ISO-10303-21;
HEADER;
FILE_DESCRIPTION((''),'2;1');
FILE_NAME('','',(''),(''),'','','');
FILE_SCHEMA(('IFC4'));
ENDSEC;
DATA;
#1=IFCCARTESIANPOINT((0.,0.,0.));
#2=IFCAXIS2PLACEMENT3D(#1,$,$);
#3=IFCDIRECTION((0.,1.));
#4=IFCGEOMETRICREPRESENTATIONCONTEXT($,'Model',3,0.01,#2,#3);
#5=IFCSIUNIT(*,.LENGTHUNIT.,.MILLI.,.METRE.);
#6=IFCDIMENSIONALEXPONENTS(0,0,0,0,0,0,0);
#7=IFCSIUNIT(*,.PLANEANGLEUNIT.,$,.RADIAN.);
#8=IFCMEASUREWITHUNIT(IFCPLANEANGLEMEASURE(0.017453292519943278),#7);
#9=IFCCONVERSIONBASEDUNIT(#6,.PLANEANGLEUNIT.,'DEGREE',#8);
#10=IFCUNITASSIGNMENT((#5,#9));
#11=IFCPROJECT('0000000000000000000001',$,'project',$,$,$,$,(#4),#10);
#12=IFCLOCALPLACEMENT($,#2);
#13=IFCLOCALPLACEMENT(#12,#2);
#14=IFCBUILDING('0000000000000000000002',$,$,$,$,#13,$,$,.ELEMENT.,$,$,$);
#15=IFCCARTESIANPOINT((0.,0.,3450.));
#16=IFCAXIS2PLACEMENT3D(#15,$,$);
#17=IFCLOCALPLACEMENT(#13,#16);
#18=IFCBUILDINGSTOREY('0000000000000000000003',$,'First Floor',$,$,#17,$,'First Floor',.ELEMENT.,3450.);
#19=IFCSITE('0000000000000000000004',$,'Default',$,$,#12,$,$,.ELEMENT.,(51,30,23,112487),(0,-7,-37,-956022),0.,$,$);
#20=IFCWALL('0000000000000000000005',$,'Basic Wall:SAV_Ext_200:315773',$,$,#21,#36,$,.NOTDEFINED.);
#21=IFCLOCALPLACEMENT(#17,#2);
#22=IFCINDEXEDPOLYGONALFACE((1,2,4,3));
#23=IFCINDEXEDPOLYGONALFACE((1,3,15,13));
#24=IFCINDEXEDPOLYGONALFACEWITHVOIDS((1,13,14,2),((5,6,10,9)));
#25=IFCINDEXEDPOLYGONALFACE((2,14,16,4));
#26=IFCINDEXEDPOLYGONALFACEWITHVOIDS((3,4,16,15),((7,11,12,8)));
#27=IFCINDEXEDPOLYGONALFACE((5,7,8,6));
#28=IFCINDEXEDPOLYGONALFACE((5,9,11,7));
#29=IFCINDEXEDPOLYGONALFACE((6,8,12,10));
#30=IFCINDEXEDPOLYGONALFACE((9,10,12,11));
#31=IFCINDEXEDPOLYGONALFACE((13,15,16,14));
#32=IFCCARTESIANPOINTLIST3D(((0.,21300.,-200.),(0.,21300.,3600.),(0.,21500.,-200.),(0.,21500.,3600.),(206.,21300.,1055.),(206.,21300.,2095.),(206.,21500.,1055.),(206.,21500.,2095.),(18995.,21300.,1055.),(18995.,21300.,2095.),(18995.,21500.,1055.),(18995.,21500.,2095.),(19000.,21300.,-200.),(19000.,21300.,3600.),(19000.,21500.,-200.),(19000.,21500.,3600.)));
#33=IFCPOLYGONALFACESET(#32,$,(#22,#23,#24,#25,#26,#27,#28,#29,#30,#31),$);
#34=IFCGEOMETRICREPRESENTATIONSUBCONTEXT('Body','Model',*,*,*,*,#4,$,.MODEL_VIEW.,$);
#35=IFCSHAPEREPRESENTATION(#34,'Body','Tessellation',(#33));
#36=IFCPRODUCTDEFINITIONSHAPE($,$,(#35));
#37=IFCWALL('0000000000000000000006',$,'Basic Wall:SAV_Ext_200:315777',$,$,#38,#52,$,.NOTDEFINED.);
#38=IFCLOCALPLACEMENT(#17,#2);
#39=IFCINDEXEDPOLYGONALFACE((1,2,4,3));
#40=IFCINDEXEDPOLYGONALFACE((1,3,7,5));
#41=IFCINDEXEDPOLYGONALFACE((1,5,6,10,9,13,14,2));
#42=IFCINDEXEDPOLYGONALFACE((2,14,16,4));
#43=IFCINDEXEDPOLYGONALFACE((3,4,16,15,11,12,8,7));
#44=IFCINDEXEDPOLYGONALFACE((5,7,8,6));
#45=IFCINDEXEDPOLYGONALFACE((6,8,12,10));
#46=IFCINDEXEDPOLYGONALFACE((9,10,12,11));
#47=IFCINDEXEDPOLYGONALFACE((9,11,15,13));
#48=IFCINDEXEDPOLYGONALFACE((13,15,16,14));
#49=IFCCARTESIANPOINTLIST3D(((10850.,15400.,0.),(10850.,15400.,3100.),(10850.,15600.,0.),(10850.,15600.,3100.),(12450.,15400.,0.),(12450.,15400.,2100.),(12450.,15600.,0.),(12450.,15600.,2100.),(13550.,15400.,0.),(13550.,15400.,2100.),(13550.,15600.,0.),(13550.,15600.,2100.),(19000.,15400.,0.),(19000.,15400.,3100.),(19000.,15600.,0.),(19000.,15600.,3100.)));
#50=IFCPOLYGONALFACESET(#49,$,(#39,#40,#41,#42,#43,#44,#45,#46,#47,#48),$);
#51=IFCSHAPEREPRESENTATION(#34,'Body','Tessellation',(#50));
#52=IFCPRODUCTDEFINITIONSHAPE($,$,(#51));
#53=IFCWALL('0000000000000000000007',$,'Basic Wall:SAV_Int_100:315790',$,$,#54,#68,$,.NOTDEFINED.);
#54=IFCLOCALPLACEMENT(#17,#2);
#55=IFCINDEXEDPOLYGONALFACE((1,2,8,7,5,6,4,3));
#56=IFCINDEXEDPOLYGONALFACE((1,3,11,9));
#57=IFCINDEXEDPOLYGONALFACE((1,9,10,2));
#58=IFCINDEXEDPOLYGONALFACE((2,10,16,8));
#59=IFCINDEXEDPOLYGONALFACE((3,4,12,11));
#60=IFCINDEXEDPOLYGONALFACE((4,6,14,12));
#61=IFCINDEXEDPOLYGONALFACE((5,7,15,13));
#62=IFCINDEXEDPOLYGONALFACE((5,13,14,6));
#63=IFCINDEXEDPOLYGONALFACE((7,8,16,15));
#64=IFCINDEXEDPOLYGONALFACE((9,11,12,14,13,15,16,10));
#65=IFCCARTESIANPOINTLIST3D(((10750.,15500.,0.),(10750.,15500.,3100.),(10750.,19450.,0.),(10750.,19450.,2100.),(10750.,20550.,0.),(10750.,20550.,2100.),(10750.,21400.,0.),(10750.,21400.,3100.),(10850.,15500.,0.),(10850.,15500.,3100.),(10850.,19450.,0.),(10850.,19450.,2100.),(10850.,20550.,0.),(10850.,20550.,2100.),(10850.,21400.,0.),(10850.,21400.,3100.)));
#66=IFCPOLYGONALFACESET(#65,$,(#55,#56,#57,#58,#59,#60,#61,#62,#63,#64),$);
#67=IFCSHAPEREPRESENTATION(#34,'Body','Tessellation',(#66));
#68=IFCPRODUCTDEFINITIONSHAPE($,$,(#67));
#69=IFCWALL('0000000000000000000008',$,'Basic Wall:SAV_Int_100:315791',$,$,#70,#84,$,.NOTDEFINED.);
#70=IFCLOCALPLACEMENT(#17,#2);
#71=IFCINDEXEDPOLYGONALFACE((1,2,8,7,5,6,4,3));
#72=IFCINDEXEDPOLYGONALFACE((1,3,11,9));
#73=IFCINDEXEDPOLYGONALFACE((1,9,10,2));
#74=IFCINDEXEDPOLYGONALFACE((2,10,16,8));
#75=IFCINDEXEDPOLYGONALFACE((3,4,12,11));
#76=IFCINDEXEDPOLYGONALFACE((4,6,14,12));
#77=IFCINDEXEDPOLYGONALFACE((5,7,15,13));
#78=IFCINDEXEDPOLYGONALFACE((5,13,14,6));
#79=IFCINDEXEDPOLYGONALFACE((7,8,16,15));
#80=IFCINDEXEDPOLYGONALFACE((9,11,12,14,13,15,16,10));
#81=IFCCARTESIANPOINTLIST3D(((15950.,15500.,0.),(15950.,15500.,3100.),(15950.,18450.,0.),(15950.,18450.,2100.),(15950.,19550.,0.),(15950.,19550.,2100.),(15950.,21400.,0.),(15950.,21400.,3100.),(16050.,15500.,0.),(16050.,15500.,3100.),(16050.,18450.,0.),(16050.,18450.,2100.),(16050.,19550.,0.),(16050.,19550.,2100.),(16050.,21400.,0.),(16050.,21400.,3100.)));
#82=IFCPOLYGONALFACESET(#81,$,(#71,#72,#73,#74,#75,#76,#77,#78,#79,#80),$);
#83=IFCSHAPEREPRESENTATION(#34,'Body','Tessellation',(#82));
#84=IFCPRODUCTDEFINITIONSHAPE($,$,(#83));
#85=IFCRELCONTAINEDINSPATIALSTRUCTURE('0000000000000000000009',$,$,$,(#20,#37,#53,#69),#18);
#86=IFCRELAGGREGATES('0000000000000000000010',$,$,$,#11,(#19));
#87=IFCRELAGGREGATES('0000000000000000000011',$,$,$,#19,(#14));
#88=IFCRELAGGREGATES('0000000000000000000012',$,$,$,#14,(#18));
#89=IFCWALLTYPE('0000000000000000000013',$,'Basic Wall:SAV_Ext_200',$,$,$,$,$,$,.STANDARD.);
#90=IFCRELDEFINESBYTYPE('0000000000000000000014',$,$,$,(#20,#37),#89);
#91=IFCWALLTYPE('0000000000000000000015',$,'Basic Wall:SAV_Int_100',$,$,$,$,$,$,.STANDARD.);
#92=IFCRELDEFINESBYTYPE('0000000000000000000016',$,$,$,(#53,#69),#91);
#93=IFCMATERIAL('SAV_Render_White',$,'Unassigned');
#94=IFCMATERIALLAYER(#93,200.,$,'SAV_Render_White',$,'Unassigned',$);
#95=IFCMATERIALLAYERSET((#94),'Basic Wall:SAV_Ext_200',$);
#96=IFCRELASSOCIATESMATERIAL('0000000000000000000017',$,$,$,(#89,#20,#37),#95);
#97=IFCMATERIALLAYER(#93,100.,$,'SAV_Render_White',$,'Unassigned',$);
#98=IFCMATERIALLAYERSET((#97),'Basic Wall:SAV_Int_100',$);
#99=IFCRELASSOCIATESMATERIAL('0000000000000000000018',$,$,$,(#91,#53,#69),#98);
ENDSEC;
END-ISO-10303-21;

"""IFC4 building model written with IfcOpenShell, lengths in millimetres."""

from ifc_helpers import new_model, entity, si_unit, converted_unit, direction, frame, frame_2d, origin, place, context, subcontext, project, spatial, rectangle, extrude, material, layer, layer_set, layer_usage, type_object, element, save


model = new_model("IFC4")

# Units and contexts
model_context = context("Model", 3, precision=0.01, world=origin(), true_north=direction((0.0, 1.0)))
body_context = subcontext(model_context, "Body", "Model", "MODEL_VIEW")
ifc_project = project(units=[si_unit("LENGTHUNIT", "METRE", prefix="MILLI"), converted_unit("PLANEANGLEUNIT", "DEGREE", entity("IfcPlaneAngleMeasure", 0.017453292519943278), si_unit("PLANEANGLEUNIT", "RADIAN"), dimensions=[0, 0, 0, 0, 0, 0, 0])], contexts=[model_context])

# Site, building, storey
site_placement = place(None, origin())
site = spatial("IfcSite", under=ifc_project, at=site_placement, Name="Default", CompositionType="ELEMENT", RefLatitude=(51, 30, 23, 112487), RefLongitude=(0, -7, -37, -956022), RefElevation=0.0)
building_placement = place(site_placement, origin())
building = spatial("IfcBuilding", under=site, at=building_placement, CompositionType="ELEMENT")
storey_placement = place(building_placement, frame((0.0, 0.0, 3450.0)))
storey = spatial("IfcBuildingStorey", under=building, at=storey_placement, Name="First Floor", LongName="First Floor", CompositionType="ELEMENT", Elevation=3450.0)

# Walls, openings
ifc_material_1 = material(Name="SAV_Render_White", Category="Unassigned")
ifc_layer_1 = layer(ifc_material_1, 200.0, Name="SAV_Render_White", Category="Unassigned")
ifc_layer_set_1 = layer_set([ifc_layer_1], Name="Basic Wall:SAV_Ext_200")
ifc_layer_usage_1 = layer_usage(ifc_layer_set_1, "AXIS2", "NEGATIVE", 100.0)
wall_type_1 = type_object("IfcWallType", Name="Basic Wall:SAV_Ext_200", PredefinedType="STANDARD", material=ifc_layer_set_1)
wall_1_placement = place(storey_placement, frame((19000.0, 21400.0, -200.0), z_axis=(0.0, 0.0, 1.0), x_axis=(-1.0, 0.0, 0.0)))
wall_1 = element("IfcWall", 1, at=wall_1_placement, inside=storey, type_object=wall_type_1, material=ifc_layer_usage_1, Name="Basic Wall:SAV_Ext_200:315773", PredefinedType="NOTDEFINED", context=body_context, shape_type="SweptSolid", body=[
    extrude(rectangle(XDim=19000.0, YDim=200.0, at=frame_2d((9500.0, 0.0), x_axis=(-1.0, 0.0))), origin(), (0.0, 0.0, 1.0), 3800.0),
])
opening_1_placement = place(wall_1_placement, frame((5.0, -100.0, 1255.0)))
element("IfcOpeningElement", 2, at=opening_1_placement, cuts=wall_1, PredefinedType="OPENING", context=body_context, shape_type="SweptSolid", body=[
    extrude(rectangle(XDim=1040.0, YDim=18789.0, at=frame_2d((520.0, 9394.5), x_axis=(-1.0, 0.0))), frame((0.0, 0.0, 0.0), z_axis=(0.0, 1.0, 0.0), x_axis=(0.0, 0.0, 1.0)), (0.0, 0.0, 1.0), 200.0),
])
ifc_layer_usage_2 = layer_usage(ifc_layer_set_1, "AXIS2", "NEGATIVE", 100.0)
wall_2_placement = place(storey_placement, frame((10850.0, 15500.0, 0.0)))
wall_2 = element("IfcWall", 3, at=wall_2_placement, inside=storey, type_object=wall_type_1, material=ifc_layer_usage_2, Name="Basic Wall:SAV_Ext_200:315777", PredefinedType="NOTDEFINED", context=body_context, shape_type="SweptSolid", body=[
    extrude(rectangle(XDim=8150.0, YDim=200.0, at=frame_2d((4075.0, 0.0), x_axis=(-1.0, 0.0))), origin(), (0.0, 0.0, 1.0), 3100.0),
])
opening_2_placement = place(wall_2_placement, frame((1600.0, -100.0, 0.0)))
element("IfcOpeningElement", 4, at=opening_2_placement, cuts=wall_2, PredefinedType="OPENING", context=body_context, shape_type="SweptSolid", body=[
    extrude(rectangle(XDim=2100.0, YDim=1100.0, at=frame_2d((1050.0, 550.0), x_axis=(1.0, 0.0))), frame((0.0, 0.0, 0.0), z_axis=(0.0, 1.0, 0.0), x_axis=(0.0, 0.0, 1.0)), (0.0, 0.0, 1.0), 200.0),
])
ifc_layer_2 = layer(ifc_material_1, 100.0, Name="SAV_Render_White", Category="Unassigned")
ifc_layer_set_2 = layer_set([ifc_layer_2], Name="Basic Wall:SAV_Int_100")
ifc_layer_usage_3 = layer_usage(ifc_layer_set_2, "AXIS2", "NEGATIVE", 50.0)
wall_type_2 = type_object("IfcWallType", Name="Basic Wall:SAV_Int_100", PredefinedType="STANDARD", material=ifc_layer_set_2)
wall_3_placement = place(storey_placement, frame((10800.0, 15500.0, 0.0), z_axis=(0.0, 0.0, 1.0), x_axis=(0.0, 1.0, 0.0)))
wall_3 = element("IfcWall", 5, at=wall_3_placement, inside=storey, type_object=wall_type_2, material=ifc_layer_usage_3, Name="Basic Wall:SAV_Int_100:315790", PredefinedType="NOTDEFINED", context=body_context, shape_type="SweptSolid", body=[
    extrude(rectangle(XDim=5900.0, YDim=100.0, at=frame_2d((2950.0, 0.0), x_axis=(1.0, 0.0))), origin(), (0.0, 0.0, 1.0), 3100.0),
])
opening_3_placement = place(wall_3_placement, frame((3950.0, -50.0, 0.0)))
element("IfcOpeningElement", 6, at=opening_3_placement, cuts=wall_3, PredefinedType="OPENING", context=body_context, shape_type="SweptSolid", body=[
    extrude(rectangle(XDim=2100.0, YDim=1100.0, at=frame_2d((1050.0, 550.0), x_axis=(1.0, 0.0))), frame((0.0, 0.0, 0.0), z_axis=(0.0, 1.0, 0.0), x_axis=(0.0, 0.0, 1.0)), (0.0, 0.0, 1.0), 100.0),
])
ifc_layer_usage_4 = layer_usage(ifc_layer_set_2, "AXIS2", "NEGATIVE", 50.0)
wall_4_placement = place(storey_placement, frame((16000.0, 15500.0, 0.0), z_axis=(0.0, 0.0, 1.0), x_axis=(0.0, 1.0, 0.0)))
wall_4 = element("IfcWall", 7, at=wall_4_placement, inside=storey, type_object=wall_type_2, material=ifc_layer_usage_4, Name="Basic Wall:SAV_Int_100:315791", PredefinedType="NOTDEFINED", context=body_context, shape_type="SweptSolid", body=[
    extrude(rectangle(XDim=5900.0, YDim=100.0, at=frame_2d((2950.0, 0.0), x_axis=(1.0, 0.0))), origin(), (0.0, 0.0, 1.0), 3100.0),
])
opening_4_placement = place(wall_4_placement, frame((2950.0, -50.0, 0.0)))
element("IfcOpeningElement", 8, at=opening_4_placement, cuts=wall_4, PredefinedType="OPENING", context=body_context, shape_type="SweptSolid", body=[
    extrude(rectangle(XDim=2100.0, YDim=1100.0, at=frame_2d((1050.0, 550.0), x_axis=(1.0, 0.0))), frame((0.0, 0.0, 0.0), z_axis=(0.0, 1.0, 0.0), x_axis=(0.0, 0.0, 1.0)), (0.0, 0.0, 1.0), 100.0),
])

save(model, "model.ifc")
